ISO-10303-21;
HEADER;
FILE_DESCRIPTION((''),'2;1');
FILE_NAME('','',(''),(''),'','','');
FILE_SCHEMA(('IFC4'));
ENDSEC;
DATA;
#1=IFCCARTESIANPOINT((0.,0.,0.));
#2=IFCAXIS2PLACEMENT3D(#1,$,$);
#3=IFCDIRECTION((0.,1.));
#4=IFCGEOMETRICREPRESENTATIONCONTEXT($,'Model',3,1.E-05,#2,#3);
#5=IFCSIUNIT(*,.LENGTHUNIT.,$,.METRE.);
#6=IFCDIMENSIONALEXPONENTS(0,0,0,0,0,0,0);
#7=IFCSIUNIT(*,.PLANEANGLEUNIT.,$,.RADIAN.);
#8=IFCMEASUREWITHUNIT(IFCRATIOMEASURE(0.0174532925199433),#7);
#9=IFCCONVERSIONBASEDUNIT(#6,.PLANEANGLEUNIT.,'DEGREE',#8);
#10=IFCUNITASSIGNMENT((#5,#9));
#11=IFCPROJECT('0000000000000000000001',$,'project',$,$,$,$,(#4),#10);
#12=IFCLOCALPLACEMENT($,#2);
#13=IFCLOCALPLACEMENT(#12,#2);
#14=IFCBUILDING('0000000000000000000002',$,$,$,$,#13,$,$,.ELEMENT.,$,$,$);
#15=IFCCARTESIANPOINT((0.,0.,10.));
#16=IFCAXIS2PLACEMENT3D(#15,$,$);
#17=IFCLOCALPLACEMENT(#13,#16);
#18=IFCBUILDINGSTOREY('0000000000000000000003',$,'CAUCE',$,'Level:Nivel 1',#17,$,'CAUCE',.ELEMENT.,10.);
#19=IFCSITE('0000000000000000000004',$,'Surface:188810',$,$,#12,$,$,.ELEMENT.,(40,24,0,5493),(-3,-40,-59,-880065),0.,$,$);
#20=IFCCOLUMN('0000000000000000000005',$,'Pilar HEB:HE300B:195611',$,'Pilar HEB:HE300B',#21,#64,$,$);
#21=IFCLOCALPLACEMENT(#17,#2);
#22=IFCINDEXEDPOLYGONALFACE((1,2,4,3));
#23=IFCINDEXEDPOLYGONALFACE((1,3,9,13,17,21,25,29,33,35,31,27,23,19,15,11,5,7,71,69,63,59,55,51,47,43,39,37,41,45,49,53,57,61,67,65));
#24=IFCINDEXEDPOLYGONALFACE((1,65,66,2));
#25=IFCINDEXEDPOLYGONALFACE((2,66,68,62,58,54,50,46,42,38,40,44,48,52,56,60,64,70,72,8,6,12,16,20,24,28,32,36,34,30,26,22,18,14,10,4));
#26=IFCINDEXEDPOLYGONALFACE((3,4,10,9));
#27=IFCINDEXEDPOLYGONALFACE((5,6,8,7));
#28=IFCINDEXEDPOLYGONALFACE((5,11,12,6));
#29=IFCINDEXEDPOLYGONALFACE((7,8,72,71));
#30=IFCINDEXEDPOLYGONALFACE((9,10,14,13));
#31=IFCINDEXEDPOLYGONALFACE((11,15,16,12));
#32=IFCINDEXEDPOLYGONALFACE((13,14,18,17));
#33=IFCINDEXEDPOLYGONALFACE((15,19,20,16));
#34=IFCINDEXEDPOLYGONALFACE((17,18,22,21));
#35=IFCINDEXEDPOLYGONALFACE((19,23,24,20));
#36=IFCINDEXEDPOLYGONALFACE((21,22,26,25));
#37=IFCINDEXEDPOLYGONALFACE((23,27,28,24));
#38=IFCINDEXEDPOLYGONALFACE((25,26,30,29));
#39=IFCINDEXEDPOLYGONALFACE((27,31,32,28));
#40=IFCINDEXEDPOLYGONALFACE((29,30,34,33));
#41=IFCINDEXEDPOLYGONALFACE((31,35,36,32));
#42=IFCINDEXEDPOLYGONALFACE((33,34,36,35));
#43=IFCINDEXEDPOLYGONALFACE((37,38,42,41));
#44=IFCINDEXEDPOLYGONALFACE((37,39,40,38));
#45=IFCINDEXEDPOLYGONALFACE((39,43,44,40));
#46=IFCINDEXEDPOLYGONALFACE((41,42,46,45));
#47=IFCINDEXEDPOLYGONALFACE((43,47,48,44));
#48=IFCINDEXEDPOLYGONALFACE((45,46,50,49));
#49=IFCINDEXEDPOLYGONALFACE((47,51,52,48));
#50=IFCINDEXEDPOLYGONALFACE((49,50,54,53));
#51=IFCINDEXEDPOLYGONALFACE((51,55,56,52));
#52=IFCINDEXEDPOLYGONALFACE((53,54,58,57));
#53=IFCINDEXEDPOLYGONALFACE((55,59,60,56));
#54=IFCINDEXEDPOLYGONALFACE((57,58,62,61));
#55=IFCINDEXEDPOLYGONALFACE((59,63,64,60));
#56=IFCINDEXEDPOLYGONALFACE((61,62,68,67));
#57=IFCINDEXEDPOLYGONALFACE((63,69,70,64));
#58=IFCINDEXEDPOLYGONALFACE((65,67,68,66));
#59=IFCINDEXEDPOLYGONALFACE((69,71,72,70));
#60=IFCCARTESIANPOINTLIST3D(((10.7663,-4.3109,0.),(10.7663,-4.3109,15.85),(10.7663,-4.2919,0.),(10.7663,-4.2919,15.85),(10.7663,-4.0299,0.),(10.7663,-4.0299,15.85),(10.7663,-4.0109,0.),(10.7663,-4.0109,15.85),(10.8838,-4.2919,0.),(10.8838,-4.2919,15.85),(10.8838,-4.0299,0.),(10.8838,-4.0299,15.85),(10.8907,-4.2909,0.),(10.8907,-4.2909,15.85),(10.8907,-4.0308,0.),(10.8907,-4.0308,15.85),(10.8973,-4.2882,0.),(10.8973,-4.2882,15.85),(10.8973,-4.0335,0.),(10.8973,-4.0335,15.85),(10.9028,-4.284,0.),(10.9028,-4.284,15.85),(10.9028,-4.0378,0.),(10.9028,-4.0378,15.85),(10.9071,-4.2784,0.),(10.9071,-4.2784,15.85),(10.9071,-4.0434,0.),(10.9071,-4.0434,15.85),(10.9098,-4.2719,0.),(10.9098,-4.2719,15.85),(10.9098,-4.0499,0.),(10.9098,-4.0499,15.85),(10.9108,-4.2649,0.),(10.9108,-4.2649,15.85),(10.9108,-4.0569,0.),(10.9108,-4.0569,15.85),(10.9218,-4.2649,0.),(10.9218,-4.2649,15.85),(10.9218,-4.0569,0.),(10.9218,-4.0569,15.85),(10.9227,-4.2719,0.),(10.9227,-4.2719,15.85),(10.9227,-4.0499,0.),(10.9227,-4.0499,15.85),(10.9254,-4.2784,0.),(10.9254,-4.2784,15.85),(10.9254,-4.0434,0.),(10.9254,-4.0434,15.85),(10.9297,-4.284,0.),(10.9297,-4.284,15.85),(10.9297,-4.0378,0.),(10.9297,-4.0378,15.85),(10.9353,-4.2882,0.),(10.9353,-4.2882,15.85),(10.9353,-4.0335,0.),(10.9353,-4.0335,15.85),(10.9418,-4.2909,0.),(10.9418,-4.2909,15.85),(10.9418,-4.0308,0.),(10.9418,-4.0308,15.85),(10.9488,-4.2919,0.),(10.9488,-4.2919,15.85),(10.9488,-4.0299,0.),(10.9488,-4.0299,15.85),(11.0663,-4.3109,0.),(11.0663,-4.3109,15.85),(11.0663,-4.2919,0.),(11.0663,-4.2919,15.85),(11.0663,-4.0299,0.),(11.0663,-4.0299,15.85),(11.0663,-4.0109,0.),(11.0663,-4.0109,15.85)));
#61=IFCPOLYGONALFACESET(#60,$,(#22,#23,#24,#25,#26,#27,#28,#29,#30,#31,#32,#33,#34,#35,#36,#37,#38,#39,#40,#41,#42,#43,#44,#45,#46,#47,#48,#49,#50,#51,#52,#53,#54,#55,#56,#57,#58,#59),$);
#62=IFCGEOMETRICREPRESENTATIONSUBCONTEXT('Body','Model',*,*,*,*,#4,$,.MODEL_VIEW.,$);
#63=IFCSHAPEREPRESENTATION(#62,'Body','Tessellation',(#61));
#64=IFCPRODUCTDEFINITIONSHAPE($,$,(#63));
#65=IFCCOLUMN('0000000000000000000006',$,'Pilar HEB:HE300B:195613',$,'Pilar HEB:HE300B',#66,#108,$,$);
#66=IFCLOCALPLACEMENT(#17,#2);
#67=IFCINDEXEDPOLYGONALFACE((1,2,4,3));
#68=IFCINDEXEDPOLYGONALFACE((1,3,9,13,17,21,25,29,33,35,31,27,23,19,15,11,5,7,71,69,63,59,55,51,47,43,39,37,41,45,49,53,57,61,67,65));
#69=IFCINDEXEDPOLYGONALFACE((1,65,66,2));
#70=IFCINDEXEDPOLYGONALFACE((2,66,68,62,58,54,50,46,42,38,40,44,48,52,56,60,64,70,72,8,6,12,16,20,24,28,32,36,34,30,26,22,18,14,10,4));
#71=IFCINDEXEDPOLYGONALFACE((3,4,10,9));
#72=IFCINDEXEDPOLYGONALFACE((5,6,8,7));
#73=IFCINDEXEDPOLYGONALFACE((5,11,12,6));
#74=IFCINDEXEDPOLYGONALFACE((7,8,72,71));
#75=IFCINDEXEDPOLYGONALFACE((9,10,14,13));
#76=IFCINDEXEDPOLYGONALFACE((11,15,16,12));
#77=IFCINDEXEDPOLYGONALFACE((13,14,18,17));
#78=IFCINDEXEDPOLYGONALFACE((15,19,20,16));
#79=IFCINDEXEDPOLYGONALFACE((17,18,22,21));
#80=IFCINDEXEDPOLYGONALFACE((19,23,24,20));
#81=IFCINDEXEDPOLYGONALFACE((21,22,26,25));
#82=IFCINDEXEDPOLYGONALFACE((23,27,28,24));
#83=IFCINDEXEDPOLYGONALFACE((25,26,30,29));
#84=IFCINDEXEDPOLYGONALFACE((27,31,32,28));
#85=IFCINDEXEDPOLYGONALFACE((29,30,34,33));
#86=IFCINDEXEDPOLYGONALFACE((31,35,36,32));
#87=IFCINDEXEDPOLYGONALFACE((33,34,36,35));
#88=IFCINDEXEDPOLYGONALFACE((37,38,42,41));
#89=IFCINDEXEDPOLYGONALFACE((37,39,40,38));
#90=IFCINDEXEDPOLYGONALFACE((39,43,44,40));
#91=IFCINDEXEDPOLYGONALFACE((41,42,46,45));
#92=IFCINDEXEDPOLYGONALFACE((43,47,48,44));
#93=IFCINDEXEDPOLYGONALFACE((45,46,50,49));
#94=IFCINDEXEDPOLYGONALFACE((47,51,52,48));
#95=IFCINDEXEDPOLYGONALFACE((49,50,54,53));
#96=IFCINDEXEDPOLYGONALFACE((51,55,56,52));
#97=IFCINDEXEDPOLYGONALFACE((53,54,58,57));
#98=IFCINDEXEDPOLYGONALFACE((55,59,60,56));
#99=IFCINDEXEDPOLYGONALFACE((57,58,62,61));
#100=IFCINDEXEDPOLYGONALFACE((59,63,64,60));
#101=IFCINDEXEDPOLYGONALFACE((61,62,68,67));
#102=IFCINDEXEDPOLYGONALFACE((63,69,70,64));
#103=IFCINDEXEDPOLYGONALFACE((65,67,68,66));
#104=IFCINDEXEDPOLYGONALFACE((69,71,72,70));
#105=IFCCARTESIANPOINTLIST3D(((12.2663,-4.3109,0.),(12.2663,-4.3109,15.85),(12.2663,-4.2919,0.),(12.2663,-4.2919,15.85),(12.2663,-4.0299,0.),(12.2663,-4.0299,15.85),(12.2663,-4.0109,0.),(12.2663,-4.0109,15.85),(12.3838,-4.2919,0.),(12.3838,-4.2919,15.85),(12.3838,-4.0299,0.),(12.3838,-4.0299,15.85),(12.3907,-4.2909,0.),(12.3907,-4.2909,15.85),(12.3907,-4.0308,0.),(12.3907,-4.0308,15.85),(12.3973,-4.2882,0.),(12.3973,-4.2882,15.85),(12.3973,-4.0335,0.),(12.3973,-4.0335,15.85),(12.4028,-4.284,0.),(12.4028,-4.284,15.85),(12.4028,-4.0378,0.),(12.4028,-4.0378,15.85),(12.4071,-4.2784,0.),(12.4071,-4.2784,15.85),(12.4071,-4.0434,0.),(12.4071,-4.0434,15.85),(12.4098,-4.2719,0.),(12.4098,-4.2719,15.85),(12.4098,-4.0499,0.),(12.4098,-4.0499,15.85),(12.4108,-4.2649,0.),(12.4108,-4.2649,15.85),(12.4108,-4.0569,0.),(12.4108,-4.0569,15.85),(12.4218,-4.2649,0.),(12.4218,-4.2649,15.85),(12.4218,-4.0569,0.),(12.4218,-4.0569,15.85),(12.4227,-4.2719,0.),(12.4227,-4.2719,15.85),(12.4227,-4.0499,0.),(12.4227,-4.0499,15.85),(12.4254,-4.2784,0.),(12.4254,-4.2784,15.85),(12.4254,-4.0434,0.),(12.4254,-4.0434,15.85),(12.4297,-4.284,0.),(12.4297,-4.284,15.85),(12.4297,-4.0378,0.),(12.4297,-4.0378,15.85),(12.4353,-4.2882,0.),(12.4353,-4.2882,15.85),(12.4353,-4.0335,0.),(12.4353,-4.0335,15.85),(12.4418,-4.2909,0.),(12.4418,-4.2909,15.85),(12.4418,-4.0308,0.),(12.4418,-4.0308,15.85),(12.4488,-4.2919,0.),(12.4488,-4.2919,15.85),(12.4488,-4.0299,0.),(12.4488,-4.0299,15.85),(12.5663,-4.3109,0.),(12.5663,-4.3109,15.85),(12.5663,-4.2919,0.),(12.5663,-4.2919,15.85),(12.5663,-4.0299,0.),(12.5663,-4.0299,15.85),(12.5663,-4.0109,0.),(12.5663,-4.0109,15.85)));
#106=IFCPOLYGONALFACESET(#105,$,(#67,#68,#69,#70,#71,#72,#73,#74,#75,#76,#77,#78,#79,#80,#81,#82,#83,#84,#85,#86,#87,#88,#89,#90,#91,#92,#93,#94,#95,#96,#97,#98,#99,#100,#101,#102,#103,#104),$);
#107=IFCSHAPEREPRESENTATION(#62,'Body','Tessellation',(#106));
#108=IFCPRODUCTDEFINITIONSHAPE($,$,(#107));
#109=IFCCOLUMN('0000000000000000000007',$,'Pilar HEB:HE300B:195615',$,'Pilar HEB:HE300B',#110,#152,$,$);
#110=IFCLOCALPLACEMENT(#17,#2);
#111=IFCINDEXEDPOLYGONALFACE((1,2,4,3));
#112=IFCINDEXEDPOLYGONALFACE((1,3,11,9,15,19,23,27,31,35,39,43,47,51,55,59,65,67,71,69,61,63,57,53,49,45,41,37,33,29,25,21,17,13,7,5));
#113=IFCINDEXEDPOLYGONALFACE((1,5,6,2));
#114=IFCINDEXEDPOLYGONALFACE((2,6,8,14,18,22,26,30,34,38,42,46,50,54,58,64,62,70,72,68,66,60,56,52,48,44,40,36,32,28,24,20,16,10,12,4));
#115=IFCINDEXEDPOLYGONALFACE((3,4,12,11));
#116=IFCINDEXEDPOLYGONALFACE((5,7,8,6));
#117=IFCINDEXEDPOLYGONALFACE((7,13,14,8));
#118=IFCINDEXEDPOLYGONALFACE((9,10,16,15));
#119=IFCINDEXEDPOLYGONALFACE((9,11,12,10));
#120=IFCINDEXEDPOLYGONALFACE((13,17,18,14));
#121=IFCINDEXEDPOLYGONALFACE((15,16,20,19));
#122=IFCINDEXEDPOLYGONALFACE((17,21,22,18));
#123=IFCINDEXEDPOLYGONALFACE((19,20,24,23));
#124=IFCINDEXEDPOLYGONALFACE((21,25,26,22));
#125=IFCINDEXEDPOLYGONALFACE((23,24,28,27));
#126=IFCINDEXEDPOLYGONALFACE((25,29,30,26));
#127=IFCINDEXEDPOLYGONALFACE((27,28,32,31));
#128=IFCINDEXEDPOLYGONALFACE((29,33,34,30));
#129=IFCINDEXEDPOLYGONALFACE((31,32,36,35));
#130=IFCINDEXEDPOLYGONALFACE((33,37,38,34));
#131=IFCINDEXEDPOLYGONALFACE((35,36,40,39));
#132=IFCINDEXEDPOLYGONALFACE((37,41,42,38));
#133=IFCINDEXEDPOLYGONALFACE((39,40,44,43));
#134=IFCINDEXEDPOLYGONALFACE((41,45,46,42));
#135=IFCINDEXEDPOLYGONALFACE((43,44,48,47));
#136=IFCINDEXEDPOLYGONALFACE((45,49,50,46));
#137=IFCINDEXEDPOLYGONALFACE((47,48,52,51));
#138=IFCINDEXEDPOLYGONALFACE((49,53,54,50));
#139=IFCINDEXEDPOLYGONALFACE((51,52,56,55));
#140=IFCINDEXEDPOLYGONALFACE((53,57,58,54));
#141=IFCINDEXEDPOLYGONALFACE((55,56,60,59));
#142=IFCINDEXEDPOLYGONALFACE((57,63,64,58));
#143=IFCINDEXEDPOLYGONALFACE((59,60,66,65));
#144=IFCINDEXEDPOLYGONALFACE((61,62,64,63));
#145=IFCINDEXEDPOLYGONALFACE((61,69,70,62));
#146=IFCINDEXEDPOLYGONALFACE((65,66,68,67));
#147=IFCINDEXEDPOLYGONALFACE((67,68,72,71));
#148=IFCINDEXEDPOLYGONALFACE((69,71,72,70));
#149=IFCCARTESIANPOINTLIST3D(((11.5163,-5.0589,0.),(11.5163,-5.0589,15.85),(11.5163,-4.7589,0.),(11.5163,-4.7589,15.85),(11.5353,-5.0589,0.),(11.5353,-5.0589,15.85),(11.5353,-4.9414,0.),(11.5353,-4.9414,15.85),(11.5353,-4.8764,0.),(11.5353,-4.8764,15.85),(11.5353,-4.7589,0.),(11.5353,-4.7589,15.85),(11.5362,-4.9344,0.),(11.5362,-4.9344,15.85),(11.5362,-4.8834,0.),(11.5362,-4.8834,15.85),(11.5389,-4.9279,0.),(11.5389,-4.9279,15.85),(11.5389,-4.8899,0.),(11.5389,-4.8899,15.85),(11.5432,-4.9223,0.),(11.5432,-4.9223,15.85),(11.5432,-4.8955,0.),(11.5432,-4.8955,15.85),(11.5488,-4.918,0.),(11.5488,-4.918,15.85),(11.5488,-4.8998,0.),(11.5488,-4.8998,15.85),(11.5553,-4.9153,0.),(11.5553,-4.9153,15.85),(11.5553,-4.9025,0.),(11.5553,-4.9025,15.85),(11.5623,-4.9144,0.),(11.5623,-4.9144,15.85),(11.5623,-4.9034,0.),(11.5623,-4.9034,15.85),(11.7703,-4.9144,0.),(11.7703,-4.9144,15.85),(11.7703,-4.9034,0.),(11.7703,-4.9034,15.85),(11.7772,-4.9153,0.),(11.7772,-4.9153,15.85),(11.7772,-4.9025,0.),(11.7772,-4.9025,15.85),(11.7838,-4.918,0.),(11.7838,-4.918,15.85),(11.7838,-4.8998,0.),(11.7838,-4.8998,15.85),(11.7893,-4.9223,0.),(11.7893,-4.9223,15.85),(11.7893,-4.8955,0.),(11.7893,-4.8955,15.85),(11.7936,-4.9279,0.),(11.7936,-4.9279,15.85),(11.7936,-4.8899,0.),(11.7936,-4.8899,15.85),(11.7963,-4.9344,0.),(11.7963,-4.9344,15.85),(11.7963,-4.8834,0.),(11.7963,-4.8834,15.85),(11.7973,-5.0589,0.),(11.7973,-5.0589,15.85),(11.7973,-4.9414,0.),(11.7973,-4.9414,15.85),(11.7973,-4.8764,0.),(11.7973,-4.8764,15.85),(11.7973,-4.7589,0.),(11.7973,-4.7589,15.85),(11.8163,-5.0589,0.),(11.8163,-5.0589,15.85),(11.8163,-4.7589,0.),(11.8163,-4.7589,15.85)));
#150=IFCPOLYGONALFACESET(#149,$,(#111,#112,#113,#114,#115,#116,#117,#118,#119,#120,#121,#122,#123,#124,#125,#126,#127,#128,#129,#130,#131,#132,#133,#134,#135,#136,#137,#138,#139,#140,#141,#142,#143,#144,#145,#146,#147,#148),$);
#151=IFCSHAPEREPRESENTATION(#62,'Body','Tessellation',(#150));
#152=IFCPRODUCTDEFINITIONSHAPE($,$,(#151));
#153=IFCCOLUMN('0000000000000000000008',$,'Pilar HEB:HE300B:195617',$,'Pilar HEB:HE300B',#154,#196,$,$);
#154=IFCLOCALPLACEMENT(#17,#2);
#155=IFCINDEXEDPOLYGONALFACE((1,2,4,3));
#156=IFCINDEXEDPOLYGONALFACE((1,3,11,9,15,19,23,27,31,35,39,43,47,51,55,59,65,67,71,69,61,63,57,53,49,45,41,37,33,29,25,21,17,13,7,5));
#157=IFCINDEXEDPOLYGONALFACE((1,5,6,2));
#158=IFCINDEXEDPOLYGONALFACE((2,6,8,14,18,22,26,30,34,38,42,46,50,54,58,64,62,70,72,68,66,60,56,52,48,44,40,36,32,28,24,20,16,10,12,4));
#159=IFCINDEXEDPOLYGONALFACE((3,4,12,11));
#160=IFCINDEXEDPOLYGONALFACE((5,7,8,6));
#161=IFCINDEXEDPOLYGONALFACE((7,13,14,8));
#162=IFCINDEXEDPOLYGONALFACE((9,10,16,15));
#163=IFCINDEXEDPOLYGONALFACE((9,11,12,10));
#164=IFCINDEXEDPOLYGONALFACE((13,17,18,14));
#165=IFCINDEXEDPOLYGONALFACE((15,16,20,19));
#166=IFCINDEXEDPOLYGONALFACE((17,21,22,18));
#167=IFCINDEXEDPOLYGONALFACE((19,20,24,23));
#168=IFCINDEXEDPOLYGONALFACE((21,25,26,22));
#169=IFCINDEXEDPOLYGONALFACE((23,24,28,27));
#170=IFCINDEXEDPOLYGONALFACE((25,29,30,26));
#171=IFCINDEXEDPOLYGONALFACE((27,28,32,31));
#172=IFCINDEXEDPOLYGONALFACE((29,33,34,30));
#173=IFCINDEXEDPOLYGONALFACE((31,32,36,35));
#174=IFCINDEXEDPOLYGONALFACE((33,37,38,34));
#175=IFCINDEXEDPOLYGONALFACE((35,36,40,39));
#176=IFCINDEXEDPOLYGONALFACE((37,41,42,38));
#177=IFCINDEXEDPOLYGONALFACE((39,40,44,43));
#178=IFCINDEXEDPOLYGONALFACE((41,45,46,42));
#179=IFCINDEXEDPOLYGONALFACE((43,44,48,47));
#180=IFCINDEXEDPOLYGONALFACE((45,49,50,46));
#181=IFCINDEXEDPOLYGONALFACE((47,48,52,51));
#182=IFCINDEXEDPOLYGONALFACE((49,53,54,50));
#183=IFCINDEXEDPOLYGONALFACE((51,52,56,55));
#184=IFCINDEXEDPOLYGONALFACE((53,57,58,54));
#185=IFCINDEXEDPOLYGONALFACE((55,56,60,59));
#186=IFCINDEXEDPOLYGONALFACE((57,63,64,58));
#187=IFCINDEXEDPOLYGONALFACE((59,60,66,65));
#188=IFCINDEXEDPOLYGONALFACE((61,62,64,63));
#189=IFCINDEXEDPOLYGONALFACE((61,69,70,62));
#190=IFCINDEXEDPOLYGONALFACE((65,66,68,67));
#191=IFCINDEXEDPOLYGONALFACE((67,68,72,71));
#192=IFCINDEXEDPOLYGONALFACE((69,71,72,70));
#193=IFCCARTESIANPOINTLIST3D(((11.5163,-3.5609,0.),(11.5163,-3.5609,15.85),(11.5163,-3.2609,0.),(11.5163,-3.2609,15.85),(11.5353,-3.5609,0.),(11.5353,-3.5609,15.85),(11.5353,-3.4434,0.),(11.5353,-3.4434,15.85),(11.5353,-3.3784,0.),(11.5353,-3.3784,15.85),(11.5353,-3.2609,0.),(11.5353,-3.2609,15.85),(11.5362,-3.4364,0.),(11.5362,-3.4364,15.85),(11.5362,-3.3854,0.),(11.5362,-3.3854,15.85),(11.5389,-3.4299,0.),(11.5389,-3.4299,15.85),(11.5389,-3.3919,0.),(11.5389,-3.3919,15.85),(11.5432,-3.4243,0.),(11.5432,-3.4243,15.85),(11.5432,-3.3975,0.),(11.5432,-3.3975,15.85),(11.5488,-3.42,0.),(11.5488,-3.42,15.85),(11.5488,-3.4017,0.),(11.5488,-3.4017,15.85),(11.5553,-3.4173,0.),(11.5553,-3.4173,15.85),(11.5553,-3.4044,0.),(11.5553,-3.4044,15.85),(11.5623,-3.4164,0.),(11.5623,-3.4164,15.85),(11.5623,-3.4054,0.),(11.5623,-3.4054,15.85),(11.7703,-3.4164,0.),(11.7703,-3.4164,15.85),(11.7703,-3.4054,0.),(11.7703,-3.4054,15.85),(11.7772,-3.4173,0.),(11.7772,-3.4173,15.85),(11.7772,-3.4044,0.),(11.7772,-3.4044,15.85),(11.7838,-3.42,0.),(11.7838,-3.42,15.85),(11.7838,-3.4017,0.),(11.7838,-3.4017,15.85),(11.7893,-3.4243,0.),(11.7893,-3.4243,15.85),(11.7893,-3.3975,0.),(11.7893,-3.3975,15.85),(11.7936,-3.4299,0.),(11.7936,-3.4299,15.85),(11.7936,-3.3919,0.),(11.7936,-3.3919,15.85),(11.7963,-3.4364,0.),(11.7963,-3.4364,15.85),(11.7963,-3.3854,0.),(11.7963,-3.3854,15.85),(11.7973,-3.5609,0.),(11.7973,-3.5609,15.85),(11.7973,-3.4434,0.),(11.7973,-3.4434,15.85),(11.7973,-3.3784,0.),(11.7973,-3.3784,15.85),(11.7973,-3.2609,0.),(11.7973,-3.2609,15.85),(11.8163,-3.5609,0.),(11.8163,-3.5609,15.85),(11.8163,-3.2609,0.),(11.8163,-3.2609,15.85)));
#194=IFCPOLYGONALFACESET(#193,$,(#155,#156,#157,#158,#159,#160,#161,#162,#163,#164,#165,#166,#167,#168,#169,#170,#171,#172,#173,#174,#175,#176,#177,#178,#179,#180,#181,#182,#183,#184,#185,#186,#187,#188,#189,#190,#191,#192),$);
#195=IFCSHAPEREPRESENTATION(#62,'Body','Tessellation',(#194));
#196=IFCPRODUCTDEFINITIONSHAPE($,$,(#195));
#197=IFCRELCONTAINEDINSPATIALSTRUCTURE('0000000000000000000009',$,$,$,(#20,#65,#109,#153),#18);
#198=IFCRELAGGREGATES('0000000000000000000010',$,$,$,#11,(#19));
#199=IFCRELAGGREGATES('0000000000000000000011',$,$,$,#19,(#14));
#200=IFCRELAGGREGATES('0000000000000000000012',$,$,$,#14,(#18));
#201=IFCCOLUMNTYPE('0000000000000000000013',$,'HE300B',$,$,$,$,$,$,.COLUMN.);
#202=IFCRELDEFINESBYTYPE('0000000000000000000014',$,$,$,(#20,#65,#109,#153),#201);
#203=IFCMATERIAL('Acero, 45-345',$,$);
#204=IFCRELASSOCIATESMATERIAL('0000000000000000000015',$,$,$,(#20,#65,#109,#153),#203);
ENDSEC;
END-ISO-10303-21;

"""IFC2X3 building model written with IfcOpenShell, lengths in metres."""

from ifc_helpers import new_model, entity, si_unit, converted_unit, direction, frame, frame_2d, origin, place, context, subcontext, project, spatial, polyline, circle_curve, parameter, trimmed, segment, composite_curve, outline, extrude, source, transform, mapped, material, type_object, type_shapes, element, save


model = new_model("IFC2X3")

# Units and contexts
model_context = context("Model", 3, precision=1e-05, world=origin(), true_north=direction((0.0, 1.0)))
body_context = subcontext(model_context, "Body", "Model", "MODEL_VIEW")
ifc_project = project(units=[si_unit("LENGTHUNIT", "METRE"), converted_unit("PLANEANGLEUNIT", "DEGREE", entity("IfcRatioMeasure", 0.0174532925199433), si_unit("PLANEANGLEUNIT", "RADIAN"), dimensions=[0, 0, 0, 0, 0, 0, 0])], contexts=[model_context])

# Site, building, storey
site_placement = place(None, origin())
site = spatial("IfcSite", under=ifc_project, at=site_placement, Name="Surface:188810", CompositionType="ELEMENT", RefLatitude=(40, 24, 0, 5493), RefLongitude=(-3, -40, -59, -880065), RefElevation=0.0)
building_placement = place(site_placement, origin())
building = spatial("IfcBuilding", under=site, at=building_placement, CompositionType="ELEMENT")
storey_placement = place(building_placement, frame((0.0, 0.0, 10.0)))
storey = spatial("IfcBuildingStorey", under=building, at=storey_placement, Name="CAUCE", ObjectType="Level:Nivel 1", LongName="CAUCE", CompositionType="ELEMENT", Elevation=10.0)

# Columns
ifc_material_1 = material(Name="Acero, 45-345")
column_type_1 = type_object("IfcColumnType", Name="HE300B", PredefinedType="COLUMN")
shared_shape_1 = source(origin(), body_context, "Body", "SweptSolid", [
    extrude(outline(composite_curve([segment(polyline([(0.131, -0.15), (0.15, -0.15)]), True, "CONTINUOUS"), segment(polyline([(0.15, -0.15), (0.15, 0.15)]), True, "CONTINUOUS"), segment(polyline([(0.15, 0.15), (0.131, 0.15)]), True, "CONTINUOUS"), segment(polyline([(0.131, 0.15), (0.131, 0.0325)]), True, "CONTINUOUS"), segment(trimmed(circle_curve(frame_2d((0.104, 0.0325), x_axis=(1.0, 0.0)), 0.027), [parameter(270.0)], [parameter(0.0)], True, "PARAMETER"), False, "CONTINUOUS"), segment(polyline([(0.104, 0.0055), (-0.104, 0.0055)]), True, "CONTINUOUS"), segment(trimmed(circle_curve(frame_2d((-0.104, 0.0325), x_axis=(0.0, -1.0)), 0.027), [parameter(270.0)], [parameter(0.0)], True, "PARAMETER"), False, "CONTINUOUS"), segment(polyline([(-0.131, 0.0325), (-0.131, 0.15)]), True, "CONTINUOUS"), segment(polyline([(-0.131, 0.15), (-0.15, 0.15)]), True, "CONTINUOUS"), segment(polyline([(-0.15, 0.15), (-0.15, -0.15)]), True, "CONTINUOUS"), segment(polyline([(-0.15, -0.15), (-0.131, -0.15)]), True, "CONTINUOUS"), segment(polyline([(-0.131, -0.15), (-0.131, -0.0325)]), True, "CONTINUOUS"), segment(trimmed(circle_curve(frame_2d((-0.104, -0.0325), x_axis=(-1.0, 0.0)), 0.027), [parameter(270.0)], [parameter(0.0)], True, "PARAMETER"), False, "CONTINUOUS"), segment(polyline([(-0.104, -0.0055), (0.104, -0.0055)]), True, "CONTINUOUS"), segment(trimmed(circle_curve(frame_2d((0.104, -0.0325), x_axis=(0.0, 1.0)), 0.027), [parameter(270.0)], [parameter(0.0)], True, "PARAMETER"), False, "CONTINUOUS"), segment(polyline([(0.131, -0.0325), (0.131, -0.15)]), True, "CONTINUOUS")], self_intersect=False)), frame((0.0, 0.0, 10.0), z_axis=(0.0, 0.0, 1.0), x_axis=(0.0, -1.0, 0.0)), (0.0, 0.0, 1.0), 15.85),
])
type_shapes(column_type_1, [shared_shape_1])
for number, where, name in (
    (1, (10.9163, -4.1609, -10.0), "Pilar HEB:HE300B:195611"),
    (2, (12.4163, -4.1609, -10.0), "Pilar HEB:HE300B:195613"),
):
    element("IfcColumn", number, at=place(storey_placement, frame(where)), inside=storey, type_object=column_type_1, material=ifc_material_1, Name=name, ObjectType="Pilar HEB:HE300B", context=body_context, shape_type="MappedRepresentation", body=[
        mapped(shared_shape_1, transform((0.0, 0.0, 0.0), scale=1.0)),
    ])
for number, where, z_axis, x_axis, name in (
    (3, (11.6663, -4.9089, -10.0), (0.0, 0.0, 1.0), (0.0, -1.0, 0.0), "Pilar HEB:HE300B:195615"),
    (4, (11.6663, -3.4109, -10.0), (0.0, 0.0, 1.0), (0.0, -1.0, 0.0), "Pilar HEB:HE300B:195617"),
):
    element("IfcColumn", number, at=place(storey_placement, frame(where, z_axis=z_axis, x_axis=x_axis)), inside=storey, type_object=column_type_1, material=ifc_material_1, Name=name, ObjectType="Pilar HEB:HE300B", context=body_context, shape_type="MappedRepresentation", body=[
        mapped(shared_shape_1, transform((0.0, 0.0, 0.0), scale=1.0)),
    ])

save(model, "model.ifc")
